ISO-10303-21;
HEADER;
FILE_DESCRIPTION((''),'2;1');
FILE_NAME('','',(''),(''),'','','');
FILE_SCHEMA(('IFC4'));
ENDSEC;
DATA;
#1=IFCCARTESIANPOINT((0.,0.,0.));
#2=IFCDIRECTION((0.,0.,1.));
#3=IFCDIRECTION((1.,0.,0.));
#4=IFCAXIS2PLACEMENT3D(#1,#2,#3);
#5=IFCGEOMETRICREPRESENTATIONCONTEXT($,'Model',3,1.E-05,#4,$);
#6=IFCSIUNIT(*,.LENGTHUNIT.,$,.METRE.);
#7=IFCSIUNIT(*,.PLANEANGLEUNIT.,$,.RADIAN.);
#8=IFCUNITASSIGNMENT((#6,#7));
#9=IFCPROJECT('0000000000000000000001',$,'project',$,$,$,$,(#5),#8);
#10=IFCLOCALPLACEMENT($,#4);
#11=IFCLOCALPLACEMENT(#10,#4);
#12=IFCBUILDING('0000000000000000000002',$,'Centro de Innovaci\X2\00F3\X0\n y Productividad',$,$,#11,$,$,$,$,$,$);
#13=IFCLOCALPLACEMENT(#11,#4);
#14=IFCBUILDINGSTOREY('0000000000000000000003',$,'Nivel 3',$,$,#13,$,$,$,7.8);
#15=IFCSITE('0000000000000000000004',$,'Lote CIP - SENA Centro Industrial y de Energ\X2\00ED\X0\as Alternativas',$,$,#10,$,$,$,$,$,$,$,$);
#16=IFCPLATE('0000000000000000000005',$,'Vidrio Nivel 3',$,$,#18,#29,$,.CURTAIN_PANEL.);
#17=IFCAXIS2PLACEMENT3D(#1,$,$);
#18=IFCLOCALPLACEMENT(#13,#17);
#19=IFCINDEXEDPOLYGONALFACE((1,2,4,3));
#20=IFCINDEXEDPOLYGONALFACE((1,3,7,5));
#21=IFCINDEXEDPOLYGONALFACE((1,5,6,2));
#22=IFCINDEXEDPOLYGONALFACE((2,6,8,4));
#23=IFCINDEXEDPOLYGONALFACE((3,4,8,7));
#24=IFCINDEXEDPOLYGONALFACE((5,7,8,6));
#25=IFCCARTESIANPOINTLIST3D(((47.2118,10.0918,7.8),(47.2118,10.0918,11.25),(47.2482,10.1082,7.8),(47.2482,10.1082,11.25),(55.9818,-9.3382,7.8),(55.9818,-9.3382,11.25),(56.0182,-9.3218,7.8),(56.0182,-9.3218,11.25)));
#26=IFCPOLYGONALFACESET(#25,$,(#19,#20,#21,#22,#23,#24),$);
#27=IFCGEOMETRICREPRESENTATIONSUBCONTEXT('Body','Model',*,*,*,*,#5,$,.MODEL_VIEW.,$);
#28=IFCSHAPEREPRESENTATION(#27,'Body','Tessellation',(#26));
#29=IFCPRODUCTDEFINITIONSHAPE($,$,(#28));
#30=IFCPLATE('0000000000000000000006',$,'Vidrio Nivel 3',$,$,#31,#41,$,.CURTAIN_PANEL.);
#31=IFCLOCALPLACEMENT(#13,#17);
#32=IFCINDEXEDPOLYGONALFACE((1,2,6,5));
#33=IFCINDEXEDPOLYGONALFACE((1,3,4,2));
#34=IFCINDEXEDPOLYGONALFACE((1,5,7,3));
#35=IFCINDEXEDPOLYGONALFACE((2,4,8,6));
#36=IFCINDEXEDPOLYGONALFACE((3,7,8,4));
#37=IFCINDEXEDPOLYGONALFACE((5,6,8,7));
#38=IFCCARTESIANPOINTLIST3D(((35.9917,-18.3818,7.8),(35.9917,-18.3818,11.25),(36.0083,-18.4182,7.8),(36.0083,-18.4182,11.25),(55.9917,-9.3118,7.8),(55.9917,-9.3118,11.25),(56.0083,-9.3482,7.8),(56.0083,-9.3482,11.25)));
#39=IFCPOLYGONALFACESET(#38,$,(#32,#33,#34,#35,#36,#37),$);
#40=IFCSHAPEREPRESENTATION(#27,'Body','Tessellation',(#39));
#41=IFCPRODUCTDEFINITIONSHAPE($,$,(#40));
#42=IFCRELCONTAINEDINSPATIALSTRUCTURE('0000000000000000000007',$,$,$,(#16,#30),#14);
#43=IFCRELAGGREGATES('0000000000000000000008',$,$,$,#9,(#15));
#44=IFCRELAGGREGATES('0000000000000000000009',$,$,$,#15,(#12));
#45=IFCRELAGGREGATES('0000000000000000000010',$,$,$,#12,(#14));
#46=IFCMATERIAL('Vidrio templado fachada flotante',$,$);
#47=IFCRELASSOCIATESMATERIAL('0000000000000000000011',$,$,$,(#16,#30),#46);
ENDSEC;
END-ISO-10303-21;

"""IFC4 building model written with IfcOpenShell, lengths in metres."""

from ifc_helpers import new_model, si_unit, frame, origin_with_axes, place, context, subcontext, project, spatial, polyline, outline, extrude, material, element, save


model = new_model("IFC4")

# Units and contexts
model_context = context("Model", 3, precision=1e-05, world=origin_with_axes())
body_context = subcontext(model_context, "Body", "Model", "MODEL_VIEW")
ifc_project = project(units=[si_unit("LENGTHUNIT", "METRE"), si_unit("PLANEANGLEUNIT", "RADIAN")], contexts=[model_context])

# Site, building, storey
site_placement = place(None, origin_with_axes())
site = spatial("IfcSite", under=ifc_project, at=site_placement, Name="Lote CIP - SENA Centro Industrial y de Energías Alternativas")
building_placement = place(site_placement, origin_with_axes())
building = spatial("IfcBuilding", under=site, at=building_placement, Name="Centro de Innovación y Productividad")
storey_placement = place(building_placement, origin_with_axes())
storey = spatial("IfcBuildingStorey", under=building, at=storey_placement, Name="Nivel 3", Elevation=7.8)

# Plates
ifc_material_1 = material(Name="Vidrio templado fachada flotante")
plate_1_placement = place(storey_placement, origin_with_axes())
element("IfcPlate", 1, at=plate_1_placement, inside=storey, material=ifc_material_1, Name="Vidrio Nivel 3", PredefinedType="CURTAIN_PANEL", context=body_context, shape_type="SweptSolid", body=[
    extrude(outline(polyline([(55.9818, -9.3382), (47.2118, 10.0918), (47.2482, 10.1082), (56.0182, -9.3218), (55.9818, -9.3382)])), frame((0.0, 0.0, 7.8)), (0.0, 0.0, 1.0), 3.45),
])
plate_2_placement = place(storey_placement, origin_with_axes())
element("IfcPlate", 2, at=plate_2_placement, inside=storey, material=ifc_material_1, Name="Vidrio Nivel 3", PredefinedType="CURTAIN_PANEL", context=body_context, shape_type="SweptSolid", body=[
    extrude(outline(polyline([(35.9917, -18.3818), (55.9917, -9.3118), (56.0083, -9.3482), (36.0083, -18.4182), (35.9917, -18.3818)])), frame((0.0, 0.0, 7.8)), (0.0, 0.0, 1.0), 3.45),
])

save(model, "model.ifc")
